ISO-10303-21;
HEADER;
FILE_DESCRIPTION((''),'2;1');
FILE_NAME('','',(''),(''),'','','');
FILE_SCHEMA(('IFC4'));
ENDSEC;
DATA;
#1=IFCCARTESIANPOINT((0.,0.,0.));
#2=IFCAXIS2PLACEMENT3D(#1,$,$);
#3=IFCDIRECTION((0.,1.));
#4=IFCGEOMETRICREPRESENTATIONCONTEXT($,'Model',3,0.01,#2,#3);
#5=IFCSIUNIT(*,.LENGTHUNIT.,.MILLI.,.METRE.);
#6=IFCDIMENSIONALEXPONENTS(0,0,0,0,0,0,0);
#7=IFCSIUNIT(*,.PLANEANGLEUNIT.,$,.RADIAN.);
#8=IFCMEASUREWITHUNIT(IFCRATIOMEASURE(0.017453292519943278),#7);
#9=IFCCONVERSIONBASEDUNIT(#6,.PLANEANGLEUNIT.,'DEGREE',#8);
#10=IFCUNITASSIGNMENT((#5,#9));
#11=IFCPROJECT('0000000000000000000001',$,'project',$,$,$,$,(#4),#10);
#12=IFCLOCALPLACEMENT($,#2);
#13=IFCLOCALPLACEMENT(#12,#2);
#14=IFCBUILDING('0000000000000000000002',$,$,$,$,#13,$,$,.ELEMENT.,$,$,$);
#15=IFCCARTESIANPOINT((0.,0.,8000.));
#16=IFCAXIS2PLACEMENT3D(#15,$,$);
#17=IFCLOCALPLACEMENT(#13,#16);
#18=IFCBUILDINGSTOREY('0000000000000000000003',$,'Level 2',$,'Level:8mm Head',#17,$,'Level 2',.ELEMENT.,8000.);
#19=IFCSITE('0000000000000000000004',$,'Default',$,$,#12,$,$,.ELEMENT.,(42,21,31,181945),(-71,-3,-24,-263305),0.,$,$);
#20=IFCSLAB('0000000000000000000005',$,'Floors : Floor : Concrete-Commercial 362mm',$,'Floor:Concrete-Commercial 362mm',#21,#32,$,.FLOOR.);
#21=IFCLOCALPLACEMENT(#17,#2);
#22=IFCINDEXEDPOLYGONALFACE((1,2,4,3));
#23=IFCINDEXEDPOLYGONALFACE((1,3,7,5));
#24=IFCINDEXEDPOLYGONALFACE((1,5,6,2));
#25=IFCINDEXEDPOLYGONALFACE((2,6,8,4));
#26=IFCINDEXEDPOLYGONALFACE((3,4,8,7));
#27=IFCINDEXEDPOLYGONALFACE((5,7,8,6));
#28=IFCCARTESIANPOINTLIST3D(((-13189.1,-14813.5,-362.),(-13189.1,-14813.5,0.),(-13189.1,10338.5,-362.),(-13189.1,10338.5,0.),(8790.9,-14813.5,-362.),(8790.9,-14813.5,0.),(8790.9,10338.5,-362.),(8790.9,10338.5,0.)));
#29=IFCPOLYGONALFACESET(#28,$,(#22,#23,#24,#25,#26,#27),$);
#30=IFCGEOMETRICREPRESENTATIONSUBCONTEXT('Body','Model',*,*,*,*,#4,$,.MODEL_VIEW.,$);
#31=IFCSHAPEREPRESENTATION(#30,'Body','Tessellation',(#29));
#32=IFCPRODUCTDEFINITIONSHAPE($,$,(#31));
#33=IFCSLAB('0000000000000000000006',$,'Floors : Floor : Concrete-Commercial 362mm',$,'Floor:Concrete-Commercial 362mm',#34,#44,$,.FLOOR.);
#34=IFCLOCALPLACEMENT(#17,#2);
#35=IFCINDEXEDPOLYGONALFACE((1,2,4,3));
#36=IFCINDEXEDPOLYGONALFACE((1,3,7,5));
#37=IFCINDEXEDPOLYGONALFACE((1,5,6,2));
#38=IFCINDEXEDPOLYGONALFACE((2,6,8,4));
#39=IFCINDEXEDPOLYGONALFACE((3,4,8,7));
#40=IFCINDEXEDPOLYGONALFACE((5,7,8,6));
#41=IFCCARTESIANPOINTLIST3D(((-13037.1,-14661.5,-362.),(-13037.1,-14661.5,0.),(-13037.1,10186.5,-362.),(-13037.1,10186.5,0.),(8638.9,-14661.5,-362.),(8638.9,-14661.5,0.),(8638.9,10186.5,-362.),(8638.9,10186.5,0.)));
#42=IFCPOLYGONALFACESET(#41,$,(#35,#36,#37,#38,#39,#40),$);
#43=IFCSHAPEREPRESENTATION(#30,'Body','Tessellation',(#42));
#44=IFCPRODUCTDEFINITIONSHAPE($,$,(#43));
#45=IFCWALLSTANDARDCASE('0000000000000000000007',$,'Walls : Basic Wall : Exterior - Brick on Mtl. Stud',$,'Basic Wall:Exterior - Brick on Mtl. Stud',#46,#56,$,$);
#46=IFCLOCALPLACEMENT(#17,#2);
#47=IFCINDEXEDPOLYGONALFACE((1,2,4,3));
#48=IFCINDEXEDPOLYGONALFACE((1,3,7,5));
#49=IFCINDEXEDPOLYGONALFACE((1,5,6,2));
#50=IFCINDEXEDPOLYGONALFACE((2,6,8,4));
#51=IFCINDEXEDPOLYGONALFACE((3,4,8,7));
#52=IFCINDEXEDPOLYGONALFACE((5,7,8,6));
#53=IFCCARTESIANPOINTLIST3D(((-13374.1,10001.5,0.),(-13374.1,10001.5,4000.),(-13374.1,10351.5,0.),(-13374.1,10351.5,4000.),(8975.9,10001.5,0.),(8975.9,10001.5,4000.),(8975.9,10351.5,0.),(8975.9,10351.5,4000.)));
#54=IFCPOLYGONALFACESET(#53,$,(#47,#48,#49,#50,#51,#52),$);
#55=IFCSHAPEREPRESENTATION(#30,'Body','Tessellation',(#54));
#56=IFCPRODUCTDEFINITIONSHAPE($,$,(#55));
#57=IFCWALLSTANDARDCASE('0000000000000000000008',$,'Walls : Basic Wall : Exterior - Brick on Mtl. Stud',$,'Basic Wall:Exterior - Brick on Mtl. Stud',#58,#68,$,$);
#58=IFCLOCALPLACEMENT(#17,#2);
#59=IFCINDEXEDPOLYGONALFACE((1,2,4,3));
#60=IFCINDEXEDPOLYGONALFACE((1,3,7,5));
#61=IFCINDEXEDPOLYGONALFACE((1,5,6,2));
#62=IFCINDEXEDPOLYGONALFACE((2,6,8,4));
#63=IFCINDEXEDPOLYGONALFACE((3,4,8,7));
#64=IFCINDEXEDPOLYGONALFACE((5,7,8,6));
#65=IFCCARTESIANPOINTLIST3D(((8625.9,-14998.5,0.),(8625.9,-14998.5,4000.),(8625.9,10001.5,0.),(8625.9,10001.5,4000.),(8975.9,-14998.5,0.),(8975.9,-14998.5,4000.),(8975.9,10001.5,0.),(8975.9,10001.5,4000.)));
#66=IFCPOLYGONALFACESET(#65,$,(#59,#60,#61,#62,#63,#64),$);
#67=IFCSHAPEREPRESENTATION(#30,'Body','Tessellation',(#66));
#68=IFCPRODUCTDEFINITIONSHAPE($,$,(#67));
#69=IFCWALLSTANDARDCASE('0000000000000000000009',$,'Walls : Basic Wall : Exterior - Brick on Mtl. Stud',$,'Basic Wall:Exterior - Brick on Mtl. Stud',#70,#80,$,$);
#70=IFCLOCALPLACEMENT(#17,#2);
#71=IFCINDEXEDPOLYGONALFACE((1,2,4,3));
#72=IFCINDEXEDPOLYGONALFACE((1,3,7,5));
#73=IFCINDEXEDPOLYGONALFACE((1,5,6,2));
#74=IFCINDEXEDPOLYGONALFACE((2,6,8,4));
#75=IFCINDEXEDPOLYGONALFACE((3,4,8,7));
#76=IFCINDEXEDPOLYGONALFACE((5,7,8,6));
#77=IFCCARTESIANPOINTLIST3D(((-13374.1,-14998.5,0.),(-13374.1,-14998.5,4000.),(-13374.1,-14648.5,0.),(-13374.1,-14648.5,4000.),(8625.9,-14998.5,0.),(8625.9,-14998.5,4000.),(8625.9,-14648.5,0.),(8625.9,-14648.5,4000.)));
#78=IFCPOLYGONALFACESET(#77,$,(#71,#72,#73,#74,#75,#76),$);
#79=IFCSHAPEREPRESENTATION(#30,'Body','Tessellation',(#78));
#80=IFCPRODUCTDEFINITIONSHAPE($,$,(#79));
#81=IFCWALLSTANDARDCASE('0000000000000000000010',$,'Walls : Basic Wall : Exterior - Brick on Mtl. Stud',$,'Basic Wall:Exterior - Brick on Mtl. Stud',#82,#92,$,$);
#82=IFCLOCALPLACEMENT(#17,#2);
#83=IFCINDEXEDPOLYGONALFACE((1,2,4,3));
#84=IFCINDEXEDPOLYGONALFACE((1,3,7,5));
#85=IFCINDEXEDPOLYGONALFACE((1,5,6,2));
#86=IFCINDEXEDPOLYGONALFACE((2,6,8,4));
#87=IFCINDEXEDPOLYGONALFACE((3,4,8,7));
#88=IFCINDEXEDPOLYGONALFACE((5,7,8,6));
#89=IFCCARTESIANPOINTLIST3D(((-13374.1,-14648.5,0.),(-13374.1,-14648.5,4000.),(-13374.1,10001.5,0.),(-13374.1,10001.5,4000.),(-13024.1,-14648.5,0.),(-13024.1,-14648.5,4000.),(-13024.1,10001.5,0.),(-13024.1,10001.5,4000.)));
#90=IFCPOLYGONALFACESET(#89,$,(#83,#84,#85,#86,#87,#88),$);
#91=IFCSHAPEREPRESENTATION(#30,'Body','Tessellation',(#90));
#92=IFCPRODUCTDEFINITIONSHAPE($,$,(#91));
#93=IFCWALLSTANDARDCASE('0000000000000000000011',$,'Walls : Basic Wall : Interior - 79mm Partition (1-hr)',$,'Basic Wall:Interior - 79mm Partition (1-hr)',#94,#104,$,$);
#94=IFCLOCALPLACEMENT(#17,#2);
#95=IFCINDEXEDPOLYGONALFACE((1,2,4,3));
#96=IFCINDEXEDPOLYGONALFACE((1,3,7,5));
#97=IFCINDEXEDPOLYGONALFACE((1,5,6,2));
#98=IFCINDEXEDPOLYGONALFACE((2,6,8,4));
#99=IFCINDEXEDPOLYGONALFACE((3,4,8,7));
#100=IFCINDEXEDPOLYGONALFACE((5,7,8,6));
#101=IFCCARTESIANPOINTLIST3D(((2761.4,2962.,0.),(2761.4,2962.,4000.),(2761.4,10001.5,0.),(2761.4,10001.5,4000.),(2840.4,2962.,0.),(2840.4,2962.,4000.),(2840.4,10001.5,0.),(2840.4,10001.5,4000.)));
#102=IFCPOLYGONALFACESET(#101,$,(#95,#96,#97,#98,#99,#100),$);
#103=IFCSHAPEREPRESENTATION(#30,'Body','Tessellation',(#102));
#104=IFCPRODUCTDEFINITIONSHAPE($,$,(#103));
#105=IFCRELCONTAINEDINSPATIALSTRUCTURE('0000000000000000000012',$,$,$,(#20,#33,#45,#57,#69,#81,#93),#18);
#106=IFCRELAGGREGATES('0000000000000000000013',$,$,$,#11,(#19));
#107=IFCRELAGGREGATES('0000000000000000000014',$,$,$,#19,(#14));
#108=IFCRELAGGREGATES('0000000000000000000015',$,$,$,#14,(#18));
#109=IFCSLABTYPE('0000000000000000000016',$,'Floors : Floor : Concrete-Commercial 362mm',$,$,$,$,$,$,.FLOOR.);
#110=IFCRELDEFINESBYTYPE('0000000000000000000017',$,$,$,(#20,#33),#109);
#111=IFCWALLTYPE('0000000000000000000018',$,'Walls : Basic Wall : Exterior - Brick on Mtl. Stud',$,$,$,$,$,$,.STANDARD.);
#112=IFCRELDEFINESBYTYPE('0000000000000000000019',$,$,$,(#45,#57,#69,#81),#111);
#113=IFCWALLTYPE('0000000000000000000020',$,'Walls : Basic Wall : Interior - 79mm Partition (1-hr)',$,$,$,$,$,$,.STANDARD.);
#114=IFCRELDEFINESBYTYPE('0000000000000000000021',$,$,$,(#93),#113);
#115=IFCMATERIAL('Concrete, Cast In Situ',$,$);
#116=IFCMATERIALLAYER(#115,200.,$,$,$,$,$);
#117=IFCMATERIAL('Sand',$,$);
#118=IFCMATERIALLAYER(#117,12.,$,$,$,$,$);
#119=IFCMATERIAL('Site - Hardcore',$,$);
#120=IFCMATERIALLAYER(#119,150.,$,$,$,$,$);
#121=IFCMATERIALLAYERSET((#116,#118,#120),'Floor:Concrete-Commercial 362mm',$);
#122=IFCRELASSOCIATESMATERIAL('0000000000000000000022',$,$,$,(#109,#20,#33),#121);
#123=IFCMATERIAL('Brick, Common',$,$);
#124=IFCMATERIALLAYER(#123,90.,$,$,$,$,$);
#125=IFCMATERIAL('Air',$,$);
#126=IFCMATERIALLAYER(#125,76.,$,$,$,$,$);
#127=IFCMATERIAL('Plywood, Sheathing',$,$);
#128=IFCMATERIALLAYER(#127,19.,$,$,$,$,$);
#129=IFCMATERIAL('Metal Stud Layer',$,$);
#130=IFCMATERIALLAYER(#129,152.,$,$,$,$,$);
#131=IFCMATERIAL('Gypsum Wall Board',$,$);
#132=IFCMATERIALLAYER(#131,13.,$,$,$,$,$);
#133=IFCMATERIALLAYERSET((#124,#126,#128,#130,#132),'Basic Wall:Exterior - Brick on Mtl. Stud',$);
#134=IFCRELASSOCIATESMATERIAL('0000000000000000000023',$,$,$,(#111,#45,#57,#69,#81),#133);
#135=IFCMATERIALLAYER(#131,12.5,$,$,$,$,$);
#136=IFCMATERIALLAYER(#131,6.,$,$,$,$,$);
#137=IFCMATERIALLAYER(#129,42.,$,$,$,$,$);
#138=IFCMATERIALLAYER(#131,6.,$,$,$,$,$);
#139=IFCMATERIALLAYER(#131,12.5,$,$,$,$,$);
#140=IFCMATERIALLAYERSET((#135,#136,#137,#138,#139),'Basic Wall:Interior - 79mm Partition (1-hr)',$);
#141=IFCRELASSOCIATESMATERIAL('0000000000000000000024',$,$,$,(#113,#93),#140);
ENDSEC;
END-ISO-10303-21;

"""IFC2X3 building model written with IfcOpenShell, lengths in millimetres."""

from ifc_helpers import new_model, entity, si_unit, converted_unit, direction, frame, frame_2d, origin, place, context, subcontext, project, spatial, rectangle, extrude, clip, halfspace, material, layer, layer_set, layer_usage, type_object, element, save


model = new_model("IFC2X3")

# Units and contexts
model_context = context("Model", 3, precision=0.01, world=origin(), true_north=direction((0.0, 1.0)))
body_context = subcontext(model_context, "Body", "Model", "MODEL_VIEW")
ifc_project = project(units=[si_unit("LENGTHUNIT", "METRE", prefix="MILLI"), converted_unit("PLANEANGLEUNIT", "DEGREE", entity("IfcRatioMeasure", 0.017453292519943278), si_unit("PLANEANGLEUNIT", "RADIAN"), dimensions=[0, 0, 0, 0, 0, 0, 0])], contexts=[model_context])

# Site, building, storey
site_placement = place(None, origin())
site = spatial("IfcSite", under=ifc_project, at=site_placement, Name="Default", CompositionType="ELEMENT", RefLatitude=(42, 21, 31, 181945), RefLongitude=(-71, -3, -24, -263305), RefElevation=0.0)
building_placement = place(site_placement, origin())
building = spatial("IfcBuilding", under=site, at=building_placement, CompositionType="ELEMENT")
storey_placement = place(building_placement, frame((0.0, 0.0, 8000.0)))
storey = spatial("IfcBuildingStorey", under=building, at=storey_placement, Name="Level 2", ObjectType="Level:8mm Head", LongName="Level 2", CompositionType="ELEMENT", Elevation=8000.0)

# Slabs
ifc_material_1 = material(Name="Concrete, Cast In Situ")
ifc_layer_1 = layer(ifc_material_1, 200.0)
ifc_material_2 = material(Name="Sand")
ifc_layer_2 = layer(ifc_material_2, 12.0)
ifc_material_3 = material(Name="Site - Hardcore")
ifc_layer_3 = layer(ifc_material_3, 150.0)
ifc_layer_set_1 = layer_set([ifc_layer_1, ifc_layer_2, ifc_layer_3], Name="Floor:Concrete-Commercial 362mm")
ifc_layer_usage_1 = layer_usage(ifc_layer_set_1, "AXIS3", "POSITIVE", 0.0)
slab_type = type_object("IfcSlabType", Name="Floors : Floor : Concrete-Commercial 362mm", PredefinedType="FLOOR", material=ifc_layer_set_1)
slab_1_placement = place(storey_placement, origin())
element("IfcSlab", 1, at=slab_1_placement, inside=storey, type_object=slab_type, material=ifc_layer_usage_1, Name="Floors : Floor : Concrete-Commercial 362mm", ObjectType="Floor:Concrete-Commercial 362mm", PredefinedType="FLOOR", context=body_context, shape_type="SweptSolid", body=[
    extrude(rectangle(XDim=25152.0, YDim=21980.0, at=frame_2d((0.0, 0.0), x_axis=(1.0, 0.0))), frame((-2199.1, -2237.5, 0.0), z_axis=(0.0, 0.0, -1.0), x_axis=(0.0, 1.0, 0.0)), (0.0, 0.0, 1.0), 362.0),
])
slab_2_placement = place(storey_placement, origin())
element("IfcSlab", 2, at=slab_2_placement, inside=storey, type_object=slab_type, material=ifc_layer_usage_1, Name="Floors : Floor : Concrete-Commercial 362mm", ObjectType="Floor:Concrete-Commercial 362mm", PredefinedType="FLOOR", context=body_context, shape_type="SweptSolid", body=[
    extrude(rectangle(XDim=24848.0, YDim=21676.0, at=frame_2d((0.0, 0.0), x_axis=(1.0, 0.0))), frame((-2199.1, -2237.5, 0.0), z_axis=(0.0, 0.0, -1.0), x_axis=(0.0, 1.0, 0.0)), (0.0, 0.0, 1.0), 362.0),
])

# Walls
ifc_material_4 = material(Name="Brick, Common")
ifc_layer_4 = layer(ifc_material_4, 90.0)
ifc_material_5 = material(Name="Air")
ifc_layer_5 = layer(ifc_material_5, 76.0)
ifc_material_6 = material(Name="Plywood, Sheathing")
ifc_layer_6 = layer(ifc_material_6, 19.0)
ifc_material_7 = material(Name="Metal Stud Layer")
ifc_layer_7 = layer(ifc_material_7, 152.0)
ifc_material_8 = material(Name="Gypsum Wall Board")
ifc_layer_8 = layer(ifc_material_8, 13.0)
ifc_layer_set_2 = layer_set([ifc_layer_4, ifc_layer_5, ifc_layer_6, ifc_layer_7, ifc_layer_8], Name="Basic Wall:Exterior - Brick on Mtl. Stud")
ifc_layer_usage_2 = layer_usage(ifc_layer_set_2, "AXIS2", "POSITIVE", -175.0)
wall_type_1 = type_object("IfcWallType", Name="Walls : Basic Wall : Exterior - Brick on Mtl. Stud", PredefinedType="STANDARD", material=ifc_layer_set_2)
wall_1_placement = place(storey_placement, frame((-13374.1, 10176.5, 0.0)))
element("IfcWallStandardCase", 3, at=wall_1_placement, inside=storey, type_object=wall_type_1, material=ifc_layer_usage_2, Name="Walls : Basic Wall : Exterior - Brick on Mtl. Stud", ObjectType="Basic Wall:Exterior - Brick on Mtl. Stud", context=body_context, shape_type="Clipping", body=[
    clip(extrude(rectangle(XDim=22350.0, YDim=350.0, at=frame_2d((11175.0, 0.0), x_axis=(-1.0, 0.0))), origin(), (0.0, 0.0, 1.0), 4000.0), halfspace(frame((0.0, 0.0, -8000.0)), True)),
])
ifc_layer_usage_3 = layer_usage(ifc_layer_set_2, "AXIS2", "NEGATIVE", 175.0)
wall_2_placement = place(storey_placement, frame((8800.9, 10001.5, 0.0), z_axis=(0.0, 0.0, 1.0), x_axis=(0.0, -1.0, 0.0)))
element("IfcWallStandardCase", 4, at=wall_2_placement, inside=storey, type_object=wall_type_1, material=ifc_layer_usage_3, Name="Walls : Basic Wall : Exterior - Brick on Mtl. Stud", ObjectType="Basic Wall:Exterior - Brick on Mtl. Stud", context=body_context, shape_type="Clipping", body=[
    clip(extrude(rectangle(XDim=25000.0, YDim=350.0, at=frame_2d((12500.0, 0.0), x_axis=(1.0, 0.0))), origin(), (0.0, 0.0, 1.0), 4000.0), halfspace(frame((0.0, 0.0, -8000.0)), True)),
])
wall_3_placement = place(storey_placement, frame((8625.9, -14823.5, 0.0), z_axis=(0.0, 0.0, 1.0), x_axis=(-1.0, 0.0, 0.0)))
element("IfcWallStandardCase", 5, at=wall_3_placement, inside=storey, type_object=wall_type_1, material=ifc_layer_usage_3, Name="Walls : Basic Wall : Exterior - Brick on Mtl. Stud", ObjectType="Basic Wall:Exterior - Brick on Mtl. Stud", context=body_context, shape_type="Clipping", body=[
    clip(extrude(rectangle(XDim=22000.0, YDim=350.0, at=frame_2d((11000.0, 0.0), x_axis=(-1.0, 0.0))), origin(), (0.0, 0.0, 1.0), 4000.0), halfspace(frame((0.0, 0.0, -8000.0)), True)),
])
wall_4_placement = place(storey_placement, frame((-13199.1, -14648.5, 0.0), z_axis=(0.0, 0.0, 1.0), x_axis=(0.0, 1.0, 0.0)))
element("IfcWallStandardCase", 6, at=wall_4_placement, inside=storey, type_object=wall_type_1, material=ifc_layer_usage_3, Name="Walls : Basic Wall : Exterior - Brick on Mtl. Stud", ObjectType="Basic Wall:Exterior - Brick on Mtl. Stud", context=body_context, shape_type="Clipping", body=[
    clip(extrude(rectangle(XDim=24650.0, YDim=350.0, at=frame_2d((12325.0, 0.0), x_axis=(-1.0, 0.0))), origin(), (0.0, 0.0, 1.0), 4000.0), halfspace(frame((0.0, 0.0, -8000.0)), True)),
])
ifc_layer_9 = layer(ifc_material_8, 12.5)
ifc_layer_10 = layer(ifc_material_8, 6.0)
ifc_layer_11 = layer(ifc_material_7, 42.0)
ifc_layer_12 = layer(ifc_material_8, 6.0)
ifc_layer_13 = layer(ifc_material_8, 12.5)
ifc_layer_set_3 = layer_set([ifc_layer_9, ifc_layer_10, ifc_layer_11, ifc_layer_12, ifc_layer_13], Name="Basic Wall:Interior - 79mm Partition (1-hr)")
ifc_layer_usage_4 = layer_usage(ifc_layer_set_3, "AXIS2", "NEGATIVE", 39.5)
wall_type_2 = type_object("IfcWallType", Name="Walls : Basic Wall : Interior - 79mm Partition (1-hr)", PredefinedType="STANDARD", material=ifc_layer_set_3)
wall_5_placement = place(storey_placement, frame((2800.9, 10001.5, 0.0), z_axis=(0.0, 0.0, 1.0), x_axis=(0.0, -1.0, 0.0)))
element("IfcWallStandardCase", 7, at=wall_5_placement, inside=storey, type_object=wall_type_2, material=ifc_layer_usage_4, Name="Walls : Basic Wall : Interior - 79mm Partition (1-hr)", ObjectType="Basic Wall:Interior - 79mm Partition (1-hr)", context=body_context, shape_type="SweptSolid", body=[
    extrude(rectangle(XDim=7039.5, YDim=79.0, at=frame_2d((3519.8, 0.0), x_axis=(-1.0, 0.0))), origin(), (0.0, 0.0, 1.0), 4000.0),
])

save(model, "model.ifc")
